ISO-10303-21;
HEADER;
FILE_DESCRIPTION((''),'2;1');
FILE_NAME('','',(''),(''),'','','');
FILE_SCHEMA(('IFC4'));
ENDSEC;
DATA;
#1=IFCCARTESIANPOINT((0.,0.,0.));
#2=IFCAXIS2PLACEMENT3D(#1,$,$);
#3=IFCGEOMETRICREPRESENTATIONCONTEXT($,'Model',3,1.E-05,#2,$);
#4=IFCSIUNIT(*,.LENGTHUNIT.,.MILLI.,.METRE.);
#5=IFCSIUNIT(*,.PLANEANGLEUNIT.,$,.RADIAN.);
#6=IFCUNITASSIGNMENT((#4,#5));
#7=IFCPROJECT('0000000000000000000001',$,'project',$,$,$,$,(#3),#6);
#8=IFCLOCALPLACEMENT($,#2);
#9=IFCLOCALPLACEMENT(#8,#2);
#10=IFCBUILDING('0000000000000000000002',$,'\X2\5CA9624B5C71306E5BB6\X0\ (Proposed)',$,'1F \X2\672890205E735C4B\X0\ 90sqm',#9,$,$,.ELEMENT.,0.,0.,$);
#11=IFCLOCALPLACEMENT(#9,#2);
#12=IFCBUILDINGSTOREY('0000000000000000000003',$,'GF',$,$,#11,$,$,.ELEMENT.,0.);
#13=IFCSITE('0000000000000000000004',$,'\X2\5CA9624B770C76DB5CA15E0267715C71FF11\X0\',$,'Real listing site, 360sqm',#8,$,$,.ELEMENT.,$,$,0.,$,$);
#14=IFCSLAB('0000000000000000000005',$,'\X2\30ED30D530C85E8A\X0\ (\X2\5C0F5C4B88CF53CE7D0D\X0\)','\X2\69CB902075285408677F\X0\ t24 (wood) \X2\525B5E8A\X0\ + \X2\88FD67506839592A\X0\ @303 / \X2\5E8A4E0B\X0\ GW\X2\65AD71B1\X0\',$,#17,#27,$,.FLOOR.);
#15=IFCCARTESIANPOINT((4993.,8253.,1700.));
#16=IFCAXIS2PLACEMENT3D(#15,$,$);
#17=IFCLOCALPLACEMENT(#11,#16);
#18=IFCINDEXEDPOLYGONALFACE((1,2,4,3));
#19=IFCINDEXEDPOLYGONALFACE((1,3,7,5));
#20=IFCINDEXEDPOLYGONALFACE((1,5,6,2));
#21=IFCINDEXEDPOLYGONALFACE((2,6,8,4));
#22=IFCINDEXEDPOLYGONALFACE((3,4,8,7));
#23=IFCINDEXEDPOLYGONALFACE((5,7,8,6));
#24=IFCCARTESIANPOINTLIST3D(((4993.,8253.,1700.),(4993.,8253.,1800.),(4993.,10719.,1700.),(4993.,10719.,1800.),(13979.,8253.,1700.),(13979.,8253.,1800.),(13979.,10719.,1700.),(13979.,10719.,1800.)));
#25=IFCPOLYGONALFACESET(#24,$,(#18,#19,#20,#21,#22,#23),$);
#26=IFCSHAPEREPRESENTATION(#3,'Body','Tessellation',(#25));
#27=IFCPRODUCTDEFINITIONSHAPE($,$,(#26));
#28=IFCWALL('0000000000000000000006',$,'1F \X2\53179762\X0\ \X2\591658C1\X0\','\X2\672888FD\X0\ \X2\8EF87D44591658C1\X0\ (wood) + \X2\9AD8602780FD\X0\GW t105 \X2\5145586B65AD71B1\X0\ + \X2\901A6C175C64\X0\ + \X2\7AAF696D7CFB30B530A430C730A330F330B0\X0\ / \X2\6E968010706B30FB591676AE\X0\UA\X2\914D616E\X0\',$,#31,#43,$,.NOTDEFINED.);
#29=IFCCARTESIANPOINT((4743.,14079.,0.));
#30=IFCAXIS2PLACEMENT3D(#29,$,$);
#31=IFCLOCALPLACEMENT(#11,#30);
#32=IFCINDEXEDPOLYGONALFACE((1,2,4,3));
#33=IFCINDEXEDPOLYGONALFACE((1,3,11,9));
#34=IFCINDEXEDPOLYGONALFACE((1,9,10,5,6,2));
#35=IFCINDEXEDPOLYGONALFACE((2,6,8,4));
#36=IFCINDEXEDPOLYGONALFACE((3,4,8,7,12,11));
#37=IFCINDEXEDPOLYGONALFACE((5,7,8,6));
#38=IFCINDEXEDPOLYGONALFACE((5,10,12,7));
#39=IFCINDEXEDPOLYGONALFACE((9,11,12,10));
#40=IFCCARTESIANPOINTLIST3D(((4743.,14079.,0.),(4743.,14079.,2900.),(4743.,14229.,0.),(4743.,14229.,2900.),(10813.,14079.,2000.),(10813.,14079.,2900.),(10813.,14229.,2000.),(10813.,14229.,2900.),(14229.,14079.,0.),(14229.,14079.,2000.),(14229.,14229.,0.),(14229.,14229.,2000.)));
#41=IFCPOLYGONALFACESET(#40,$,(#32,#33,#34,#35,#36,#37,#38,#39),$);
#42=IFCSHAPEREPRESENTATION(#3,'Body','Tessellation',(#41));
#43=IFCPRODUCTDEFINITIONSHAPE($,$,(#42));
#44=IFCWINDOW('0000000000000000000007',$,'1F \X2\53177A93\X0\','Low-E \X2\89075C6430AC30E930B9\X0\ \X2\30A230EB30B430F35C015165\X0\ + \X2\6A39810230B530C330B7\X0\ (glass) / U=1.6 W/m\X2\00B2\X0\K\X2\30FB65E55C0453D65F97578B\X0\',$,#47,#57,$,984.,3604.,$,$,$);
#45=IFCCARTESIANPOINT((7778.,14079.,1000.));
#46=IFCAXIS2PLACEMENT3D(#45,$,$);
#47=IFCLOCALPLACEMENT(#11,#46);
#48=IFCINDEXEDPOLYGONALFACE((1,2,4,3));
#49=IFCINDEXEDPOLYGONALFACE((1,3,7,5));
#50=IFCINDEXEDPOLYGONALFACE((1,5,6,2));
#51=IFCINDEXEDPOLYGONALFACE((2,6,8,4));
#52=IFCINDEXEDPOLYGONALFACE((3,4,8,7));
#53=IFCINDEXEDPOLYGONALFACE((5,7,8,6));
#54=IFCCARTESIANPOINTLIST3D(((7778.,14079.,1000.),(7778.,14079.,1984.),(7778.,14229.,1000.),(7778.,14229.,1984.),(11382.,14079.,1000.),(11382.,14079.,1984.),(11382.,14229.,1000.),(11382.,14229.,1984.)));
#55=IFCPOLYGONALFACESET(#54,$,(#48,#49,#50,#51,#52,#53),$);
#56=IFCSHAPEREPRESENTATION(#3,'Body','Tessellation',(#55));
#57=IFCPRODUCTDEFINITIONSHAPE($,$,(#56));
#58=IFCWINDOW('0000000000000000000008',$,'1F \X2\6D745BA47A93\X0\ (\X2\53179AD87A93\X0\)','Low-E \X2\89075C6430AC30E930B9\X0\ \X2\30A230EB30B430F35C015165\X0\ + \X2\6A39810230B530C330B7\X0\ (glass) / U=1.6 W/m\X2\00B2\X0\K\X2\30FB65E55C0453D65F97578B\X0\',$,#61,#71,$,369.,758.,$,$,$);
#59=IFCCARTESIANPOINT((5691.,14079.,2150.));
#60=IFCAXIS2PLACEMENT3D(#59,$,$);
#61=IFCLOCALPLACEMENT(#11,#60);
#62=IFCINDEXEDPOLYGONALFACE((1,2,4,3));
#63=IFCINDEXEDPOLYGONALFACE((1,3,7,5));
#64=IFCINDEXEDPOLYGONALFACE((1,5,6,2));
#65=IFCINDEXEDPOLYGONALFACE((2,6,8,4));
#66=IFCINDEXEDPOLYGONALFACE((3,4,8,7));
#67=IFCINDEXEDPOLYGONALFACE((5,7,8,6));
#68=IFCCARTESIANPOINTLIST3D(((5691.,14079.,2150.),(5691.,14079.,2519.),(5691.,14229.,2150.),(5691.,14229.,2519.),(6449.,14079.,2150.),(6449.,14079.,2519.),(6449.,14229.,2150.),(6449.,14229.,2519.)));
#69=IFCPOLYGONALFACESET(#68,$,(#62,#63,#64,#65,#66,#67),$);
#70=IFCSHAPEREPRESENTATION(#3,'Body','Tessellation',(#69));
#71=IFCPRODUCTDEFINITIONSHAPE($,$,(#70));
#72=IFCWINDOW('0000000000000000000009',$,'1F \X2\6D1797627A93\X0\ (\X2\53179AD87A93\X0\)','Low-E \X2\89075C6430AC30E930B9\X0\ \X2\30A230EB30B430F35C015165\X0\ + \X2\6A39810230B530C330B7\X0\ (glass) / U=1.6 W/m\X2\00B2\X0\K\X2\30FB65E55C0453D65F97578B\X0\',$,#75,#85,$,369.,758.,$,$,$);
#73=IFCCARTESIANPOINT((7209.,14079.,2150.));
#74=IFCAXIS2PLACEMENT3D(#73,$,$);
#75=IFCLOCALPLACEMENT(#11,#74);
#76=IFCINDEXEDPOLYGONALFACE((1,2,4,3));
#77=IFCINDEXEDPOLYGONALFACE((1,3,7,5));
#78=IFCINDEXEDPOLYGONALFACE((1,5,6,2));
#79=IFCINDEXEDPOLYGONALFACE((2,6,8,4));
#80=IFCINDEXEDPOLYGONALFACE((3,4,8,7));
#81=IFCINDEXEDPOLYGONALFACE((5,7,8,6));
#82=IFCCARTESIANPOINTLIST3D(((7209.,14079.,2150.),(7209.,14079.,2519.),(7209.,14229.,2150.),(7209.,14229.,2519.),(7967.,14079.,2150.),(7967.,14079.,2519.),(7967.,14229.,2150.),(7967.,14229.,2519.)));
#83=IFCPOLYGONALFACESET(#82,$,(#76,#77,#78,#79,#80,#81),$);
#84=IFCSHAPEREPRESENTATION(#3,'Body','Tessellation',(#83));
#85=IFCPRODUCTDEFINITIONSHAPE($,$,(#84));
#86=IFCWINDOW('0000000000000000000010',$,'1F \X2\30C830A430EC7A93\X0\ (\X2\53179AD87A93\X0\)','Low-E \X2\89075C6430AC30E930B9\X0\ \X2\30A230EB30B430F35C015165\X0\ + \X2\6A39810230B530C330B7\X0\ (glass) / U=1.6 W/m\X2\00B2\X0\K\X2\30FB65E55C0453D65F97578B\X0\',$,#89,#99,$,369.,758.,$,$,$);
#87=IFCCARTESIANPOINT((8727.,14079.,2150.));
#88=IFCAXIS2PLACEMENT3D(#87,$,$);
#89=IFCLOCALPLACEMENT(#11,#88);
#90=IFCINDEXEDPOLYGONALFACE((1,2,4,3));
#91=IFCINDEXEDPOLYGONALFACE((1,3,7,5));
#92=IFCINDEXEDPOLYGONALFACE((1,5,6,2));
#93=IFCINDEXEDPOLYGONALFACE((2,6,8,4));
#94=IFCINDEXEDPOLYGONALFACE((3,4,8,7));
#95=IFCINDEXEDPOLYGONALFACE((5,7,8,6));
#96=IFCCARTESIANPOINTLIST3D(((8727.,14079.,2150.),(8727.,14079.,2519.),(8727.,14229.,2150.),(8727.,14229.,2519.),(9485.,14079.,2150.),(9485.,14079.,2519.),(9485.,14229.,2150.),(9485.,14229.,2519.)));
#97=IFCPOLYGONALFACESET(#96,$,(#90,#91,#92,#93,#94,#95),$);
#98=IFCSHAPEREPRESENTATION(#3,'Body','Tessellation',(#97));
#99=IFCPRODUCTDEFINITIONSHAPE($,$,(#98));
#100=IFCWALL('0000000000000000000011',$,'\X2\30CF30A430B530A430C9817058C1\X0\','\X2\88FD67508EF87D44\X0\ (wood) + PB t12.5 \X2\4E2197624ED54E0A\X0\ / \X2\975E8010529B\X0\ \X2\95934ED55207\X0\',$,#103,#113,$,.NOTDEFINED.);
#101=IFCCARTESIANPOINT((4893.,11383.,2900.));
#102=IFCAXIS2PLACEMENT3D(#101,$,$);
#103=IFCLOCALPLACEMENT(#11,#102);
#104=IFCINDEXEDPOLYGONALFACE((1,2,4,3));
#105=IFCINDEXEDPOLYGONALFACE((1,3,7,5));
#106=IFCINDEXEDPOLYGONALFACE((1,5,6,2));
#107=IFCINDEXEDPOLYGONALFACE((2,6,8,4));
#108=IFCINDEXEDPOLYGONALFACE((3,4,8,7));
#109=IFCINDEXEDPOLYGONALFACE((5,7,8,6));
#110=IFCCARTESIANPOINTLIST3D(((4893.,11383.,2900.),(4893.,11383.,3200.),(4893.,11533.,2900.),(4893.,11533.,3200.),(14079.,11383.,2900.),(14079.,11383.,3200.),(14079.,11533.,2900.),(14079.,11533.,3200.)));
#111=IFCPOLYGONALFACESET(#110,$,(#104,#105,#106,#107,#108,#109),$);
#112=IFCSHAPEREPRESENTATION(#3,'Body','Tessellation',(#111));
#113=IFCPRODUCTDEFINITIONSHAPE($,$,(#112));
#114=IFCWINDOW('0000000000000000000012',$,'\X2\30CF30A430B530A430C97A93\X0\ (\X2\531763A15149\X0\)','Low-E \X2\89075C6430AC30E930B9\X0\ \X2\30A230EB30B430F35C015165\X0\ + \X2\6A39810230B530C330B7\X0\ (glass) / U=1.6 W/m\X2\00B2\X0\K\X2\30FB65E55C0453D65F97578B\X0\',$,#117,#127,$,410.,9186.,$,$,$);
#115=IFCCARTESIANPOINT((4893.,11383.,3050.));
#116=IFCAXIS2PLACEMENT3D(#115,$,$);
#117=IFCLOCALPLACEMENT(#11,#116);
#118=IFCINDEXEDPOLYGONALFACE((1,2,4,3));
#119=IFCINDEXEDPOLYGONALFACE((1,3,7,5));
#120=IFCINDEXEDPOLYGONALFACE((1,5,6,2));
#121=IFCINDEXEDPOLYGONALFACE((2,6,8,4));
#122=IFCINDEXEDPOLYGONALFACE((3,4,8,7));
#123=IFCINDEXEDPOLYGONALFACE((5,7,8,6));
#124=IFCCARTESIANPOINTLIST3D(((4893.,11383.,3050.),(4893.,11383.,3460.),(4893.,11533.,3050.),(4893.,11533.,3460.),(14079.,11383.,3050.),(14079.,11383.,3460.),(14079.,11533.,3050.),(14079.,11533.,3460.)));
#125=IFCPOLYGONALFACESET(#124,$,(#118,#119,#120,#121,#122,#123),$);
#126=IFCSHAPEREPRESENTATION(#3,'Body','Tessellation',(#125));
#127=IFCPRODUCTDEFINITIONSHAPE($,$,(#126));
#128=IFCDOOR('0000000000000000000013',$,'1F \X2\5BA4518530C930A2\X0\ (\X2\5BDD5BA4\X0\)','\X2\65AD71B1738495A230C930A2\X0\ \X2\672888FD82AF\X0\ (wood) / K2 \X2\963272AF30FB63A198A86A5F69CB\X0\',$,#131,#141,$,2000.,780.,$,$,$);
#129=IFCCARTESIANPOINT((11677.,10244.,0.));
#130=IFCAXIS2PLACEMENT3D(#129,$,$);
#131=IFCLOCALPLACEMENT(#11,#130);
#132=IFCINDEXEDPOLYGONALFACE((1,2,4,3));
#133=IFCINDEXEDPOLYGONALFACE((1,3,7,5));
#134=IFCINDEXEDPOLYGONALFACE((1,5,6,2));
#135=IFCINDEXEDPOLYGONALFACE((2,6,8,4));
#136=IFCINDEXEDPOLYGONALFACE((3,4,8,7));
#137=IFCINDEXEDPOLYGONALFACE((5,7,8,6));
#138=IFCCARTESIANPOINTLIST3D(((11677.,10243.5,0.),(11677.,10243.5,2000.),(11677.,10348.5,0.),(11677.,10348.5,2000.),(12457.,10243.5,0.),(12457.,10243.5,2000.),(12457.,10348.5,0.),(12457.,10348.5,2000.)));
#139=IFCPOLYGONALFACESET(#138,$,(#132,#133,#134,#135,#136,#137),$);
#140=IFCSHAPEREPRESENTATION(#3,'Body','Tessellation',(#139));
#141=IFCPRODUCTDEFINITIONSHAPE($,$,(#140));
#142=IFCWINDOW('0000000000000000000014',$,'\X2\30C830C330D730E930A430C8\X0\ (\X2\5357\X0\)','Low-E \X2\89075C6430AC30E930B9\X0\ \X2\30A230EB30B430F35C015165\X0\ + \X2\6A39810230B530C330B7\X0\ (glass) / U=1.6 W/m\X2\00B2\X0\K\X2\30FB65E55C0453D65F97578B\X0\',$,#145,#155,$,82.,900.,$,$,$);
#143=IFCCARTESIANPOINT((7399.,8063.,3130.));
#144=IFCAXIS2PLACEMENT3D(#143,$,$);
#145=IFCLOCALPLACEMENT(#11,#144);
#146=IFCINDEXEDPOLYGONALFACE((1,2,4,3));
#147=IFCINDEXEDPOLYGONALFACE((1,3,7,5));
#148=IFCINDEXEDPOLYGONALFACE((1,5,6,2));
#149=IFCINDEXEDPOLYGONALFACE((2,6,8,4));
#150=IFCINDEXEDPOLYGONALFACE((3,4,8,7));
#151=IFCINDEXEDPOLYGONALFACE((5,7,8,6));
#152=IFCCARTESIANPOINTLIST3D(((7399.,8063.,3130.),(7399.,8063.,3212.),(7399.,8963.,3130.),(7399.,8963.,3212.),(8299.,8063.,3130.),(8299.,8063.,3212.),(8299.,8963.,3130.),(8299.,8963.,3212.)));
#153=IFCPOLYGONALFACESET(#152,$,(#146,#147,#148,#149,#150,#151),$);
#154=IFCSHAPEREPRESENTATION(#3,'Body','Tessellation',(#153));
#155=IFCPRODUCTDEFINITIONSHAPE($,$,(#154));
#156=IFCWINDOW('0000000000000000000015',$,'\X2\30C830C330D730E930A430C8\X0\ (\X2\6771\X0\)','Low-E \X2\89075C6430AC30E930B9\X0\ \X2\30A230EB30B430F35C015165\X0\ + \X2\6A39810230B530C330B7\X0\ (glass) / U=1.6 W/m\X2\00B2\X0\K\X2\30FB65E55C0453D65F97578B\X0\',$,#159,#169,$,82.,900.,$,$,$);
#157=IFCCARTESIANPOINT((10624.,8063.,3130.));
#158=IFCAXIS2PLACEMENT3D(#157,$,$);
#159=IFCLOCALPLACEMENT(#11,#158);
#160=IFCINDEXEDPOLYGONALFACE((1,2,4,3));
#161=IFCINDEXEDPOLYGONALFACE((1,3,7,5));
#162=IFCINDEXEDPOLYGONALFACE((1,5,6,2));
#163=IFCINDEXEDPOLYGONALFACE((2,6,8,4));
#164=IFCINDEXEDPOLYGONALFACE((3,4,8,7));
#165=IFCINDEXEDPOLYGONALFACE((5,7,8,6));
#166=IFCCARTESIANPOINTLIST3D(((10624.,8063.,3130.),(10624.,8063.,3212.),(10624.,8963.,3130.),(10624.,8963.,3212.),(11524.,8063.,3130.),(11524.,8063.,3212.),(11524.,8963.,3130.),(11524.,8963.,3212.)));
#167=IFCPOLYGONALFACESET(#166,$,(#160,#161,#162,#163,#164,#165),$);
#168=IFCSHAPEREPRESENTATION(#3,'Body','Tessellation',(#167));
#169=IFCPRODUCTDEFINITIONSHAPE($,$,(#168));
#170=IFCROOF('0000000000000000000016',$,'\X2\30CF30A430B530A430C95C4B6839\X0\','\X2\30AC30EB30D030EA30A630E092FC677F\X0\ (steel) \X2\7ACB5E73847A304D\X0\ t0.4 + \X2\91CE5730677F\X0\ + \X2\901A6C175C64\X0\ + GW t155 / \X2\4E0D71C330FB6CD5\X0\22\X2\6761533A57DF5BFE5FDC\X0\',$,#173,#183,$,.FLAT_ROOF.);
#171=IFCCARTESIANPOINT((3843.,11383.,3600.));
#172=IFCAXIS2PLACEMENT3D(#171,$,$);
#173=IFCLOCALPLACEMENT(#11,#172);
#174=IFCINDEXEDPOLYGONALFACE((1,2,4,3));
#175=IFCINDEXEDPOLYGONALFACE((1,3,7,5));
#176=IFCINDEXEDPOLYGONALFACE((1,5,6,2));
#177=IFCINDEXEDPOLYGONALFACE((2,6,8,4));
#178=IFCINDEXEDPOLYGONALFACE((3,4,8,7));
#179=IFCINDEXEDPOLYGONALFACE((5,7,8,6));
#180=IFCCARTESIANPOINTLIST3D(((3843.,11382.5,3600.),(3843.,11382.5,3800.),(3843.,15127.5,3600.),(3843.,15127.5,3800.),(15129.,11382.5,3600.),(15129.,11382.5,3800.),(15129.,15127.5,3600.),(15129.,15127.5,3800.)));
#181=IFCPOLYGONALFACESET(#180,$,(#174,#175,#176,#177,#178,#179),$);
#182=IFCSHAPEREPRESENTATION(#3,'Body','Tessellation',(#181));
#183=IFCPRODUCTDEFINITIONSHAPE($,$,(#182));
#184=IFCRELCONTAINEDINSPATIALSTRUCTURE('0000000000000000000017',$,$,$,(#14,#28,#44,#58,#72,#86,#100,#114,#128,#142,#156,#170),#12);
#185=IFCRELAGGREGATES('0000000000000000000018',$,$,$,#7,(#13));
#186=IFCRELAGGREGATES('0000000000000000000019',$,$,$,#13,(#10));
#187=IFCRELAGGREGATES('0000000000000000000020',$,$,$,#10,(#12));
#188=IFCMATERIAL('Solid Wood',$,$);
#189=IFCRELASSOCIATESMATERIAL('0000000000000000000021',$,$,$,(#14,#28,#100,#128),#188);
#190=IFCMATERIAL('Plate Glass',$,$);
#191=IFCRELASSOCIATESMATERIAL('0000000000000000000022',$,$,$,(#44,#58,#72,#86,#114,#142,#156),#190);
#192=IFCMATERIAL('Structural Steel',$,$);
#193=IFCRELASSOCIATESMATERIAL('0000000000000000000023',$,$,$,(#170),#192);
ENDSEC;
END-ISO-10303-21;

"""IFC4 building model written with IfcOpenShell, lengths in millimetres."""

from ifc_helpers import new_model, si_unit, frame, frame_2d, origin, place, context, project, spatial, rectangle, extrude, material, element, fill, save


model = new_model("IFC4")

# Units and contexts
model_context = context("Model", 3, precision=1e-05, world=origin())
ifc_project = project(units=[si_unit("LENGTHUNIT", "METRE", prefix="MILLI"), si_unit("PLANEANGLEUNIT", "RADIAN")], contexts=[model_context])

# Site, building, storey
site_placement = place(None, origin())
site = spatial("IfcSite", under=ifc_project, at=site_placement, Name="岩手県盛岡市東山１", ObjectType="Real listing site, 360sqm", CompositionType="ELEMENT", RefElevation=0.0)
building_placement = place(site_placement, origin())
building = spatial("IfcBuilding", under=site, at=building_placement, Name="岩手山の家 (Proposed)", ObjectType="1F 木造平屋 90sqm", CompositionType="ELEMENT", ElevationOfRefHeight=0.0, ElevationOfTerrain=0.0)
storey_placement = place(building_placement, origin())
storey = spatial("IfcBuildingStorey", under=building, at=storey_placement, Name="GF", CompositionType="ELEMENT", Elevation=0.0)

# Slab
ifc_material_1 = material(Name="Solid Wood")
slab_placement = place(storey_placement, frame((4993.0, 8253.0, 1700.0)))
element("IfcSlab", 1, at=slab_placement, inside=storey, material=ifc_material_1, Name="ロフト床 (小屋裏収納)", Description="構造用合板 t24 (wood) 剛床 + 製材根太 @303 / 床下 GW断熱", PredefinedType="FLOOR", context=model_context, shape_type="SweptSolid", body=[
    extrude(rectangle(XDim=8986.0, YDim=2466.0, at=frame_2d((4493.0, 1233.0))), frame((4993.0, 8253.0, 1700.0)), (0.0, 0.0, 1.0), 100.0),
])

# Wall, openings, windows
wall_1_placement = place(storey_placement, frame((4743.0, 14079.0, 0.0)))
wall_1 = element("IfcWall", 2, at=wall_1_placement, inside=storey, material=ifc_material_1, Name="1F 北面 外壁", Description="木製 軸組外壁 (wood) + 高性能GW t105 充填断熱 + 通気層 + 窯業系サイディング / 準耐火・外皮UA配慮", PredefinedType="NOTDEFINED", context=model_context, shape_type="SweptSolid", body=[
    extrude(rectangle(XDim=9486.0, YDim=150.0, at=frame_2d((4743.0, 75.0))), frame((4743.0, 14079.0, 0.0)), (0.0, 0.0, 1.0), 2900.0),
])
opening_1_placement = place(storey_placement, frame((7778.0, 14079.0, 1000.0)))
opening_1 = element("IfcOpeningElement", 3, at=opening_1_placement, cuts=wall_1, PredefinedType="NOTDEFINED", context=model_context, shape_type="SweptSolid", body=[
    extrude(rectangle(XDim=3604.0, YDim=150.0, at=frame_2d((1802.0, 75.0))), frame((7778.0, 14079.0, 1000.0)), (0.0, 0.0, 1.0), 984.0),
])
opening_2_placement = place(storey_placement, frame((5691.0, 14079.0, 2150.0)))
opening_2 = element("IfcOpeningElement", 4, at=opening_2_placement, cuts=wall_1, PredefinedType="NOTDEFINED", context=model_context, shape_type="SweptSolid", body=[
    extrude(rectangle(XDim=758.0, YDim=150.0, at=frame_2d((379.0, 75.0))), frame((5691.0, 14079.0, 2150.0)), (0.0, 0.0, 1.0), 369.0),
])
opening_3_placement = place(storey_placement, frame((7209.0, 14079.0, 2150.0)))
opening_3 = element("IfcOpeningElement", 5, at=opening_3_placement, cuts=wall_1, PredefinedType="NOTDEFINED", context=model_context, shape_type="SweptSolid", body=[
    extrude(rectangle(XDim=758.0, YDim=150.0, at=frame_2d((379.0, 75.0))), frame((7209.0, 14079.0, 2150.0)), (0.0, 0.0, 1.0), 369.0),
])
opening_4_placement = place(storey_placement, frame((8727.0, 14079.0, 2150.0)))
opening_4 = element("IfcOpeningElement", 6, at=opening_4_placement, cuts=wall_1, PredefinedType="NOTDEFINED", context=model_context, shape_type="SweptSolid", body=[
    extrude(rectangle(XDim=758.0, YDim=150.0, at=frame_2d((379.0, 75.0))), frame((8727.0, 14079.0, 2150.0)), (0.0, 0.0, 1.0), 369.0),
])
ifc_material_2 = material(Name="Plate Glass")
window_1_placement = place(storey_placement, frame((7778.0, 14079.0, 1000.0)))
window_1 = element("IfcWindow", 7, at=window_1_placement, inside=storey, material=ifc_material_2, Name="1F 北窓", Description="Low-E 複層ガラス アルゴン封入 + 樹脂サッシ (glass) / U=1.6 W/m²K・日射取得型", OverallHeight=984.0, OverallWidth=3604.0, context=model_context, shape_type="SweptSolid", body=[
    extrude(rectangle(XDim=3604.0, YDim=150.0, at=frame_2d((1802.0, 75.0))), frame((7778.0, 14079.0, 1000.0)), (0.0, 0.0, 1.0), 984.0),
])
fill(opening_1, window_1)
window_2_placement = place(storey_placement, frame((5691.0, 14079.0, 2150.0)))
window_2 = element("IfcWindow", 8, at=window_2_placement, inside=storey, material=ifc_material_2, Name="1F 浴室窓 (北高窓)", Description="Low-E 複層ガラス アルゴン封入 + 樹脂サッシ (glass) / U=1.6 W/m²K・日射取得型", OverallHeight=369.0, OverallWidth=758.0, context=model_context, shape_type="SweptSolid", body=[
    extrude(rectangle(XDim=758.0, YDim=150.0, at=frame_2d((379.0, 75.0))), frame((5691.0, 14079.0, 2150.0)), (0.0, 0.0, 1.0), 369.0),
])
fill(opening_2, window_2)
window_3_placement = place(storey_placement, frame((7209.0, 14079.0, 2150.0)))
window_3 = element("IfcWindow", 9, at=window_3_placement, inside=storey, material=ifc_material_2, Name="1F 洗面窓 (北高窓)", Description="Low-E 複層ガラス アルゴン封入 + 樹脂サッシ (glass) / U=1.6 W/m²K・日射取得型", OverallHeight=369.0, OverallWidth=758.0, context=model_context, shape_type="SweptSolid", body=[
    extrude(rectangle(XDim=758.0, YDim=150.0, at=frame_2d((379.0, 75.0))), frame((7209.0, 14079.0, 2150.0)), (0.0, 0.0, 1.0), 369.0),
])
fill(opening_3, window_3)
window_4_placement = place(storey_placement, frame((8727.0, 14079.0, 2150.0)))
window_4 = element("IfcWindow", 10, at=window_4_placement, inside=storey, material=ifc_material_2, Name="1F トイレ窓 (北高窓)", Description="Low-E 複層ガラス アルゴン封入 + 樹脂サッシ (glass) / U=1.6 W/m²K・日射取得型", OverallHeight=369.0, OverallWidth=758.0, context=model_context, shape_type="SweptSolid", body=[
    extrude(rectangle(XDim=758.0, YDim=150.0, at=frame_2d((379.0, 75.0))), frame((8727.0, 14079.0, 2150.0)), (0.0, 0.0, 1.0), 369.0),
])
fill(opening_4, window_4)

# Wall, opening, window
wall_2_placement = place(storey_placement, frame((4893.0, 11383.0, 2900.0)))
wall_2 = element("IfcWall", 11, at=wall_2_placement, inside=storey, material=ifc_material_1, Name="ハイサイド腰壁", Description="製材軸組 (wood) + PB t12.5 両面仕上 / 非耐力 間仕切", PredefinedType="NOTDEFINED", context=model_context, shape_type="SweptSolid", body=[
    extrude(rectangle(XDim=9186.0, YDim=150.0, at=frame_2d((4593.0, 75.0))), frame((4893.0, 11383.0, 2900.0)), (0.0, 0.0, 1.0), 700.0),
])
opening_5_placement = place(storey_placement, frame((4893.0, 11383.0, 3050.0)))
opening_5 = element("IfcOpeningElement", 12, at=opening_5_placement, cuts=wall_2, PredefinedType="NOTDEFINED", context=model_context, shape_type="SweptSolid", body=[
    extrude(rectangle(XDim=9186.0, YDim=150.0, at=frame_2d((4593.0, 75.0))), frame((4893.0, 11383.0, 3050.0)), (0.0, 0.0, 1.0), 410.0),
])
window_5_placement = place(storey_placement, frame((4893.0, 11383.0, 3050.0)))
window_5 = element("IfcWindow", 13, at=window_5_placement, inside=storey, material=ifc_material_2, Name="ハイサイド窓 (北採光)", Description="Low-E 複層ガラス アルゴン封入 + 樹脂サッシ (glass) / U=1.6 W/m²K・日射取得型", OverallHeight=410.0, OverallWidth=9186.0, context=model_context, shape_type="SweptSolid", body=[
    extrude(rectangle(XDim=9186.0, YDim=150.0, at=frame_2d((4593.0, 75.0))), frame((4893.0, 11383.0, 3050.0)), (0.0, 0.0, 1.0), 410.0),
])
fill(opening_5, window_5)

# Door
door_1_placement = place(storey_placement, frame((11677.0, 10244.0, 0.0)))
element("IfcDoor", 14, at=door_1_placement, inside=storey, material=ifc_material_1, Name="1F 室内ドア (寝室)", Description="断熱玄関ドア 木製芯 (wood) / K2 防犯・採風機構", OverallHeight=2000.0, OverallWidth=780.0, context=model_context, shape_type="SweptSolid", body=[
    extrude(rectangle(XDim=780.0, YDim=105.0, at=frame_2d((390.0, 52.0))), frame((11677.0, 10244.0, 0.0)), (0.0, 0.0, 1.0), 2000.0),
])

# Windows
window_6_placement = place(storey_placement, frame((7399.0, 8063.0, 3130.0)))
element("IfcWindow", 15, at=window_6_placement, inside=storey, material=ifc_material_2, Name="トップライト (南)", Description="Low-E 複層ガラス アルゴン封入 + 樹脂サッシ (glass) / U=1.6 W/m²K・日射取得型", OverallHeight=82.0, OverallWidth=900.0, context=model_context, shape_type="SweptSolid", body=[
    extrude(rectangle(XDim=900.0, YDim=900.0, at=frame_2d((450.0, 450.0))), frame((7399.0, 8063.0, 3130.0)), (0.0, 0.0, 1.0), 82.0),
])
window_7_placement = place(storey_placement, frame((10624.0, 8063.0, 3130.0)))
element("IfcWindow", 16, at=window_7_placement, inside=storey, material=ifc_material_2, Name="トップライト (東)", Description="Low-E 複層ガラス アルゴン封入 + 樹脂サッシ (glass) / U=1.6 W/m²K・日射取得型", OverallHeight=82.0, OverallWidth=900.0, context=model_context, shape_type="SweptSolid", body=[
    extrude(rectangle(XDim=900.0, YDim=900.0, at=frame_2d((450.0, 450.0))), frame((10624.0, 8063.0, 3130.0)), (0.0, 0.0, 1.0), 82.0),
])

# Roof
ifc_material_3 = material(Name="Structural Steel")
roof_placement = place(storey_placement, frame((3843.0, 11383.0, 3600.0)))
element("IfcRoof", 17, at=roof_placement, inside=storey, material=ifc_material_3, Name="ハイサイド屋根", Description="ガルバリウム鋼板 (steel) 立平葺き t0.4 + 野地板 + 通気層 + GW t155 / 不燃・法22条区域対応", PredefinedType="FLAT_ROOF", context=model_context, shape_type="SweptSolid", body=[
    extrude(rectangle(XDim=11286.0, YDim=3745.0, at=frame_2d((5643.0, 1872.0))), frame((3843.0, 11383.0, 3600.0)), (0.0, 0.0, 1.0), 200.0),
])

save(model, "model.ifc")
